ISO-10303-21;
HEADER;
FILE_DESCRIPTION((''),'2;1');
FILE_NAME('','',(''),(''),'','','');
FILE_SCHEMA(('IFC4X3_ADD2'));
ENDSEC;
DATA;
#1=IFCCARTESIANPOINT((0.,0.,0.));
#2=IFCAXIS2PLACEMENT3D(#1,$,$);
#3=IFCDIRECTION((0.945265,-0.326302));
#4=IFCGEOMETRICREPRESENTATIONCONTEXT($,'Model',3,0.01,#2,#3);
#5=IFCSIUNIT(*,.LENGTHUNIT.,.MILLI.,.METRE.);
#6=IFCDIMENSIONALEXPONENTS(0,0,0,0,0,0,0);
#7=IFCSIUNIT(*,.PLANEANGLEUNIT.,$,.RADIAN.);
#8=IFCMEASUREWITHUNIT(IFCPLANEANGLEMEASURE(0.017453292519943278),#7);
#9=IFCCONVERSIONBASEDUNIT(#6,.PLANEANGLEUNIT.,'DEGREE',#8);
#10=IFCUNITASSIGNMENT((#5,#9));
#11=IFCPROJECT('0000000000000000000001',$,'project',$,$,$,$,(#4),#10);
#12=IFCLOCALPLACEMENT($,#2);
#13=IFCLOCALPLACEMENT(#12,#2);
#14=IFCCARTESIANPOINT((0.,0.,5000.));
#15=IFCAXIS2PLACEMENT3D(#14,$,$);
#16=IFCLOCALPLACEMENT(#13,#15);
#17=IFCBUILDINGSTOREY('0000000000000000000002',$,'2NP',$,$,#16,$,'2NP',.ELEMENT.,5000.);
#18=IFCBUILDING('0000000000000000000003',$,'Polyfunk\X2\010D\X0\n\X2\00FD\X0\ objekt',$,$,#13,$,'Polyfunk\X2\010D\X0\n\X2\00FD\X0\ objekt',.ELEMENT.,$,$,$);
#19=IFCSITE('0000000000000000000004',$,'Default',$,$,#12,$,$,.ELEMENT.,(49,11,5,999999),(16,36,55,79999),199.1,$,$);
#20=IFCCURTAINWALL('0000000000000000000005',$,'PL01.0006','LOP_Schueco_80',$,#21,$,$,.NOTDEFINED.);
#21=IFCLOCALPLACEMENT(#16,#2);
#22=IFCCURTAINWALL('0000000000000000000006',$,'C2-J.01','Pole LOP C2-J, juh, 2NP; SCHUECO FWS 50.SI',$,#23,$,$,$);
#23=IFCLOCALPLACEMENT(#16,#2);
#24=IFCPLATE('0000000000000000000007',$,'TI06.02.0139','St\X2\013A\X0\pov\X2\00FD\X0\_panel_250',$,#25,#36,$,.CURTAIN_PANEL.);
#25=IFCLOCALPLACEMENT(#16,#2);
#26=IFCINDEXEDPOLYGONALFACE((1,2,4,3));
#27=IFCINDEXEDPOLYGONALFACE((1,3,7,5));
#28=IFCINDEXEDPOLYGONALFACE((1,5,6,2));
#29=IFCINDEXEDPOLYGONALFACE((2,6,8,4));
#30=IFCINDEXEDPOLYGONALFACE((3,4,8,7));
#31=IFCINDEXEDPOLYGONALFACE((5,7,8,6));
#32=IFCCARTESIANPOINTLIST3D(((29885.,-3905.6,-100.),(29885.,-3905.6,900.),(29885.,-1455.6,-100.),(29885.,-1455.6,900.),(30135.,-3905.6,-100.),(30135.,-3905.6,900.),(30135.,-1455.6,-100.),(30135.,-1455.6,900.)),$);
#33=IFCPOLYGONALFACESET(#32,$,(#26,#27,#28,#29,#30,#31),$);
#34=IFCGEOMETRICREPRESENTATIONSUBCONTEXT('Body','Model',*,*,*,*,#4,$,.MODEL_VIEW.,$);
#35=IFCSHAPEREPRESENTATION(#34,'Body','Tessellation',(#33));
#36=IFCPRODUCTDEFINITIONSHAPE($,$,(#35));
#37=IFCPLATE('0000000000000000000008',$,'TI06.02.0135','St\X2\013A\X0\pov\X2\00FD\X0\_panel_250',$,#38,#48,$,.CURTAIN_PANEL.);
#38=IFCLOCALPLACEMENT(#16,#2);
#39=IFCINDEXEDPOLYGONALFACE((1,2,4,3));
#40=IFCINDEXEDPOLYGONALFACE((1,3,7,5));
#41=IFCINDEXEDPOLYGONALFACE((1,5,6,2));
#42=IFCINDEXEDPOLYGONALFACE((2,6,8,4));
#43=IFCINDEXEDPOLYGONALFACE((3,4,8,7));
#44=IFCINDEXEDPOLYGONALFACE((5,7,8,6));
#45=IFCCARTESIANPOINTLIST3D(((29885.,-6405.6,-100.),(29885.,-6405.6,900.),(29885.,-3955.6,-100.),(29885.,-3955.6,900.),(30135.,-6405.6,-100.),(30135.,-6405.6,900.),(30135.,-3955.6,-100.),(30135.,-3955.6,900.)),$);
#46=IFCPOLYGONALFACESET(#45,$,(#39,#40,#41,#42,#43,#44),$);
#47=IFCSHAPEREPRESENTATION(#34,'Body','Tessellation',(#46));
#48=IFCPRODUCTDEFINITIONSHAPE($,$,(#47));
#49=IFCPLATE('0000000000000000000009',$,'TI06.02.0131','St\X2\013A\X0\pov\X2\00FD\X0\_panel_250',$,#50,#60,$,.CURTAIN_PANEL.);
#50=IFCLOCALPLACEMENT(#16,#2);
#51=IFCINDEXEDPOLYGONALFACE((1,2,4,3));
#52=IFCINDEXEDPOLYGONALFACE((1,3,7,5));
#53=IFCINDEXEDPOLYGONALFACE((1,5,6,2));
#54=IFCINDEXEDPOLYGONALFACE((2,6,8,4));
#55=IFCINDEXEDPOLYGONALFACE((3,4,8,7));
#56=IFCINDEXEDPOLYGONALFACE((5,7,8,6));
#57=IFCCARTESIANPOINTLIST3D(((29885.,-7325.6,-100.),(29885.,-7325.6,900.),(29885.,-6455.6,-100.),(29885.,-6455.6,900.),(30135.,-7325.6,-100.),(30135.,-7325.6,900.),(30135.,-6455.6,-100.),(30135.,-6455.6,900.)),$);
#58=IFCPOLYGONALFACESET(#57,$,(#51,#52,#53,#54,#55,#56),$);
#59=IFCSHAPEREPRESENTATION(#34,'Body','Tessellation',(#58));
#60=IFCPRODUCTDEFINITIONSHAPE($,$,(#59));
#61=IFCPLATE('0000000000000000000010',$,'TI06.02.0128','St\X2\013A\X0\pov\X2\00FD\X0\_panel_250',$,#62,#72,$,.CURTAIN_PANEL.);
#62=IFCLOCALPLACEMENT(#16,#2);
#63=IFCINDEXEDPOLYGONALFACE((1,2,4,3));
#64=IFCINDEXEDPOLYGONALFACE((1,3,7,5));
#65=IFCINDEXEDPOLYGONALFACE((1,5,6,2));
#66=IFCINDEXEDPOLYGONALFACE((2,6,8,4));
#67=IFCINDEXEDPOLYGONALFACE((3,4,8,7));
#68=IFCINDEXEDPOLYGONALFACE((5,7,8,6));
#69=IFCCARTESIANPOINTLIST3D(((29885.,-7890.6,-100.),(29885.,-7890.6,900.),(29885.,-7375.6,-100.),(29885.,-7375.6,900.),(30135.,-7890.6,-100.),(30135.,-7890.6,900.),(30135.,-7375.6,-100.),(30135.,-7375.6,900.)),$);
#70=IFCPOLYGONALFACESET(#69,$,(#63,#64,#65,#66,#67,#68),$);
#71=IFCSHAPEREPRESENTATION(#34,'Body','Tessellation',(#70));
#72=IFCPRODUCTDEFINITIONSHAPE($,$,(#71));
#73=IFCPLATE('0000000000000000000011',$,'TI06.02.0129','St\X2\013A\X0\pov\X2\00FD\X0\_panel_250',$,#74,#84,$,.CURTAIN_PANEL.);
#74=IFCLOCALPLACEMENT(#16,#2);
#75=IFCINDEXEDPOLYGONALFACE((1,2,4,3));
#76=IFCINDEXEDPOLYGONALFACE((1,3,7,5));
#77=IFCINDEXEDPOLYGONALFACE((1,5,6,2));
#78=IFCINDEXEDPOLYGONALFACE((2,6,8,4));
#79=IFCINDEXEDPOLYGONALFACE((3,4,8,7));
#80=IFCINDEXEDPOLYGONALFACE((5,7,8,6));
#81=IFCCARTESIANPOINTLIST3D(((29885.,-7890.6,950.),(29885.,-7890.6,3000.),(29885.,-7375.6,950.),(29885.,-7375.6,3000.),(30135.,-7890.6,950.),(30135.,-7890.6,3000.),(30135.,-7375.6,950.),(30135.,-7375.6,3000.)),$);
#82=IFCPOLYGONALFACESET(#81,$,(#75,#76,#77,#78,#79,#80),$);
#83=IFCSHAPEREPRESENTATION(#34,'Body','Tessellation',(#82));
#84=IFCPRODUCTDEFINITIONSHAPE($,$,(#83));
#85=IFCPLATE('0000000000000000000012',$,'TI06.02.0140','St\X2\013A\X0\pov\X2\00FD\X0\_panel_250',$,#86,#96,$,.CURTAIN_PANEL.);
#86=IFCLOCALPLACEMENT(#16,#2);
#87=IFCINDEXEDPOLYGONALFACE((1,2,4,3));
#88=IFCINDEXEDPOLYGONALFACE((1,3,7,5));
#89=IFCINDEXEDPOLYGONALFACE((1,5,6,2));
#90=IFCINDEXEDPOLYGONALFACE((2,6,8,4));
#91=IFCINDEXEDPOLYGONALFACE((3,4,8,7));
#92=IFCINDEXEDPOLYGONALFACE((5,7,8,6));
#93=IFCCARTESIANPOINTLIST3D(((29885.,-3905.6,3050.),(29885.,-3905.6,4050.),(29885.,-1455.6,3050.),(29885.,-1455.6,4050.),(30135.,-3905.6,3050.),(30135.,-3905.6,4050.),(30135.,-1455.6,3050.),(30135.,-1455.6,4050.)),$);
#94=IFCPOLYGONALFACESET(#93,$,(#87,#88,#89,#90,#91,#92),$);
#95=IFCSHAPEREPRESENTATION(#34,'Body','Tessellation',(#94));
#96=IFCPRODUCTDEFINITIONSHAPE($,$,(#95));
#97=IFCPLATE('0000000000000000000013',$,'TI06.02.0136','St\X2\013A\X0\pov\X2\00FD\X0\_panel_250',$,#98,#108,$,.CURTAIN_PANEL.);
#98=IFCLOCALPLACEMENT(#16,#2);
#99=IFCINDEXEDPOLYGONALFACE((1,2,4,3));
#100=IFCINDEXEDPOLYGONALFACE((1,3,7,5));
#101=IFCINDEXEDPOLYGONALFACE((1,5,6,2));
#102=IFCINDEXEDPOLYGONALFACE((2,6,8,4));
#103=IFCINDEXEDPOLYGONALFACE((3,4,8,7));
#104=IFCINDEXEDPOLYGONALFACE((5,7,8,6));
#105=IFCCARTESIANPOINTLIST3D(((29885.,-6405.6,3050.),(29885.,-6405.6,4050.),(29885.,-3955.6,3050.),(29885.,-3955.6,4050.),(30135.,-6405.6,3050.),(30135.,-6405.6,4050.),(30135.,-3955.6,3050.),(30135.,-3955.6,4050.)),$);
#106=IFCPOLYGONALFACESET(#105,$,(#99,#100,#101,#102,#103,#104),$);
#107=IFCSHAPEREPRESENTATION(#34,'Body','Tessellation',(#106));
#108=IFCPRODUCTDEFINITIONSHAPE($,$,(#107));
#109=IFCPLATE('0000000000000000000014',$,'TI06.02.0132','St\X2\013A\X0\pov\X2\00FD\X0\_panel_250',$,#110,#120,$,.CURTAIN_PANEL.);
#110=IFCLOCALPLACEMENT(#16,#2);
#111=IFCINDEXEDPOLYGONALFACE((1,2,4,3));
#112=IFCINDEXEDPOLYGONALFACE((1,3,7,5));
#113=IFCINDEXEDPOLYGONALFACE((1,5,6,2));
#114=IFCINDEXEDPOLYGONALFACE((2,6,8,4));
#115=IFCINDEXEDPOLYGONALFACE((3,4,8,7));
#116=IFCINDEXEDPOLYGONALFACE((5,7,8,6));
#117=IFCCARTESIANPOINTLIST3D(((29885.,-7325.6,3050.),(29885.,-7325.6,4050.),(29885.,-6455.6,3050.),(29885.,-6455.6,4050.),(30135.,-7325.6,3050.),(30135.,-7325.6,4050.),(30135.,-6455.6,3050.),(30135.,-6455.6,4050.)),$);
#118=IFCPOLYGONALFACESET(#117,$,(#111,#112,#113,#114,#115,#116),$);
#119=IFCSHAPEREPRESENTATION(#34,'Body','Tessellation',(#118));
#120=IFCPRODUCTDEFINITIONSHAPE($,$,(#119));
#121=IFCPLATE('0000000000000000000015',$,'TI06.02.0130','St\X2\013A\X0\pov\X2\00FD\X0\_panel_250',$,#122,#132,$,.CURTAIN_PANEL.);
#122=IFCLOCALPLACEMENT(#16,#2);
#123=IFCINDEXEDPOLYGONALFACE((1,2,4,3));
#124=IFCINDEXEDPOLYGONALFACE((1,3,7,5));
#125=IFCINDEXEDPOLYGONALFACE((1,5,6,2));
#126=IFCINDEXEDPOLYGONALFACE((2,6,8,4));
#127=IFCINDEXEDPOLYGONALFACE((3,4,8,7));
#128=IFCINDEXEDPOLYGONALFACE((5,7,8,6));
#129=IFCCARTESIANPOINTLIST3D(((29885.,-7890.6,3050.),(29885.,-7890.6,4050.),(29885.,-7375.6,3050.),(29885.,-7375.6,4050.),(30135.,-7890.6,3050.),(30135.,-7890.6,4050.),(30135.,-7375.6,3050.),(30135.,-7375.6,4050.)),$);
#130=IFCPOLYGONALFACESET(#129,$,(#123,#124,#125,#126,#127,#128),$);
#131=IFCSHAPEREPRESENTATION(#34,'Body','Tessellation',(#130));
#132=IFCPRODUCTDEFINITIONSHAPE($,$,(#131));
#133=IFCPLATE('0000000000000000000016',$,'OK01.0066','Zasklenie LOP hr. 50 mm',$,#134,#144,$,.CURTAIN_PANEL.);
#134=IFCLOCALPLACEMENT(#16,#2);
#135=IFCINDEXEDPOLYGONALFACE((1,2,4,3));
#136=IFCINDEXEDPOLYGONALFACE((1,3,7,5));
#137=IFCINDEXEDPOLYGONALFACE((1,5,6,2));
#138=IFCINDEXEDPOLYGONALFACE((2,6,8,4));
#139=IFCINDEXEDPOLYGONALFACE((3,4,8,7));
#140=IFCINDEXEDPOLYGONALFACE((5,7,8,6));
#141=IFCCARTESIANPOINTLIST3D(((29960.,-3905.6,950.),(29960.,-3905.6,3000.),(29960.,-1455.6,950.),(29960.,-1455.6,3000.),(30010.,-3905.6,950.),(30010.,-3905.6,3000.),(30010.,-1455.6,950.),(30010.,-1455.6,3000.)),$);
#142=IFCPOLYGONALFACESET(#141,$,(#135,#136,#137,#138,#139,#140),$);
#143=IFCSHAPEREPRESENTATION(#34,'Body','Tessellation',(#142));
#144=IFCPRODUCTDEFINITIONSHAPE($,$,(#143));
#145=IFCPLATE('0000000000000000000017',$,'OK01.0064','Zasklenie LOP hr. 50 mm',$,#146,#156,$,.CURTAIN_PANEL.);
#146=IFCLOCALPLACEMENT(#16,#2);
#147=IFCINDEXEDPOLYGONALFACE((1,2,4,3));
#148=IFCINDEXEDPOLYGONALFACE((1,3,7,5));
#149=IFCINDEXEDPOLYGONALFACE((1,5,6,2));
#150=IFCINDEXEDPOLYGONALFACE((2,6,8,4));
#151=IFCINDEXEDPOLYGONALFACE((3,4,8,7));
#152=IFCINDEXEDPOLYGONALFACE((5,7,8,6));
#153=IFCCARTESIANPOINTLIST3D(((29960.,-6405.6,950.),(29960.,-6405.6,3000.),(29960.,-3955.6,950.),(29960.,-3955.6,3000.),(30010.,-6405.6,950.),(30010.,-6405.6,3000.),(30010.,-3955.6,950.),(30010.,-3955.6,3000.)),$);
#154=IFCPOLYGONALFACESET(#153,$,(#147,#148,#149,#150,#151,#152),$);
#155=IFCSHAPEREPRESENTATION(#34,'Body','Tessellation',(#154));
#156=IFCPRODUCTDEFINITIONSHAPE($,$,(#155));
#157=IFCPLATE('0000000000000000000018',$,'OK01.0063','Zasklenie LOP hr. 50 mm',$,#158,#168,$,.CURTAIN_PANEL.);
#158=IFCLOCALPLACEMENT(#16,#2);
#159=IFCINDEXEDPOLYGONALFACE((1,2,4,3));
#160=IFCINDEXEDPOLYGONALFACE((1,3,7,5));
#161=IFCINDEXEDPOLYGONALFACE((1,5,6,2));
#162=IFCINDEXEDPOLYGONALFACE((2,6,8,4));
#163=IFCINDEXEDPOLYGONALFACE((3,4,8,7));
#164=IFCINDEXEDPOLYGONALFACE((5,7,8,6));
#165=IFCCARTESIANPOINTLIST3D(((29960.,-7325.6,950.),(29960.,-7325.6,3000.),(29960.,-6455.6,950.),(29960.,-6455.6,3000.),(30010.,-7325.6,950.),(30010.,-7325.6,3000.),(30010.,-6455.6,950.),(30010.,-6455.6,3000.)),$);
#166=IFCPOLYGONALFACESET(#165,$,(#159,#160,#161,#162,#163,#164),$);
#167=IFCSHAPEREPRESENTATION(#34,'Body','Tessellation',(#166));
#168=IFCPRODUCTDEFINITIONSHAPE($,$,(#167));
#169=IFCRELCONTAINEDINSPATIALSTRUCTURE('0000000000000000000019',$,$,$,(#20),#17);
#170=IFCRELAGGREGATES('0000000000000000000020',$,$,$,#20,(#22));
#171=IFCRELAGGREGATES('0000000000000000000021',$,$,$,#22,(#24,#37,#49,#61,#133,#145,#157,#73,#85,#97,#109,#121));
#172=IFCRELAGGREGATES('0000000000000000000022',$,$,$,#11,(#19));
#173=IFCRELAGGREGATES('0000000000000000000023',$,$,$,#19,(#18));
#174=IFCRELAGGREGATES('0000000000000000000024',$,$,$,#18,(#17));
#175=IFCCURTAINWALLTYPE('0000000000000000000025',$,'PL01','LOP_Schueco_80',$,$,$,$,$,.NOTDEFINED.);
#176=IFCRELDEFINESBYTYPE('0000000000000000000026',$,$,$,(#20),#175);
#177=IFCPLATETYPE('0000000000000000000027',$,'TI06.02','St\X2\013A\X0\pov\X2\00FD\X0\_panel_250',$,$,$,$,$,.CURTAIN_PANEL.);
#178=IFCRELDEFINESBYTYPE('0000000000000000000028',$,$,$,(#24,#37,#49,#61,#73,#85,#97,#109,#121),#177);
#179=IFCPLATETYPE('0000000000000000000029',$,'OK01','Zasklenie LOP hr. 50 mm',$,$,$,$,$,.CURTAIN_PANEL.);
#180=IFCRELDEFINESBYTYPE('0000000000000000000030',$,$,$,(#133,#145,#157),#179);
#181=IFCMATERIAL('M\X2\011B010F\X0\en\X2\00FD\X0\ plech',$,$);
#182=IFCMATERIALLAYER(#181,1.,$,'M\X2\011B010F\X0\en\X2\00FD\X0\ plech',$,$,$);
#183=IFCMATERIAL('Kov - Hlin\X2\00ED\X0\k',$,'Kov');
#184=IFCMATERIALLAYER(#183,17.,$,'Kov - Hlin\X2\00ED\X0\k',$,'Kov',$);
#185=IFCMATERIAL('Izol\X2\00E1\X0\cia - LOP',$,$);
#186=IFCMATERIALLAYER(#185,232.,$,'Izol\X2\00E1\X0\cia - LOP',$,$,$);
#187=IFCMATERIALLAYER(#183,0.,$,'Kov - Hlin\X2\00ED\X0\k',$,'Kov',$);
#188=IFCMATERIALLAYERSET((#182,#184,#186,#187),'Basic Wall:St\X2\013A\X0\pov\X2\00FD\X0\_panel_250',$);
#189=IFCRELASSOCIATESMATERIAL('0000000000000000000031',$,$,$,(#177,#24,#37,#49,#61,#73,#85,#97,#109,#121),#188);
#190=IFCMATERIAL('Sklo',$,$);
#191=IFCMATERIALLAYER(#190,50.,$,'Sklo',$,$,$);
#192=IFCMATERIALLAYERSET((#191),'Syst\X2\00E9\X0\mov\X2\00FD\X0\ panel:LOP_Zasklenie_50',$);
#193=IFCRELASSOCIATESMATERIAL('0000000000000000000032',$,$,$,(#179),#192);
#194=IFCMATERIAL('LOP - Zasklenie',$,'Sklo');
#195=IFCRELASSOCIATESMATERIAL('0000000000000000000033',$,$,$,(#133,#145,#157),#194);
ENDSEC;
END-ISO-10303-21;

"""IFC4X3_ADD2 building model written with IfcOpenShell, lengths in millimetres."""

from ifc_helpers import new_model, entity, si_unit, converted_unit, direction, frame, frame_2d, origin, origin_2d_with_axis, place, context, subcontext, project, spatial, rectangle, extrude, source, transform, mapped, material, layer, layer_set, layer_usage, type_object, type_shapes, element, aggregate, save


model = new_model("IFC4X3_ADD2")

# Units and contexts
model_context = context("Model", 3, precision=0.01, world=origin(), true_north=direction((0.945265, -0.326302)))
body_context = subcontext(model_context, "Body", "Model", "MODEL_VIEW")
ifc_project = project(units=[si_unit("LENGTHUNIT", "METRE", prefix="MILLI"), converted_unit("PLANEANGLEUNIT", "DEGREE", entity("IfcPlaneAngleMeasure", 0.017453292519943278), si_unit("PLANEANGLEUNIT", "RADIAN"), dimensions=[0, 0, 0, 0, 0, 0, 0])], contexts=[model_context])

# Site, building, storey
site_placement = place(None, origin())
site = spatial("IfcSite", under=ifc_project, at=site_placement, Name="Default", CompositionType="ELEMENT", RefLatitude=(49, 11, 5, 999999), RefLongitude=(16, 36, 55, 79999), RefElevation=199.1)
building_placement = place(site_placement, origin())
building = spatial("IfcBuilding", under=site, at=building_placement, Name="Polyfunkčný objekt", LongName="Polyfunkčný objekt", CompositionType="ELEMENT")
storey_placement = place(building_placement, frame((0.0, 0.0, 5000.0)))
storey = spatial("IfcBuildingStorey", under=building, at=storey_placement, Name="2NP", LongName="2NP", CompositionType="ELEMENT", Elevation=5000.0)

# Curtain walls
curtain_wall_type = type_object("IfcCurtainWallType", Name="PL01", Description="LOP_Schueco_80", PredefinedType="NOTDEFINED")
curtain_wall_1_placement = place(storey_placement, frame((0.0, 0.0, -5000.0)))
curtain_wall_1 = element("IfcCurtainWall", 1, at=curtain_wall_1_placement, inside=storey, type_object=curtain_wall_type, Name="PL01.0006", Description="LOP_Schueco_80", PredefinedType="NOTDEFINED")
curtain_wall_2 = element("IfcCurtainWall", 2, Name="C2-J.01", Description="Pole LOP C2-J, juh, 2NP; SCHUECO FWS 50.SI")
aggregate(curtain_wall_1, [curtain_wall_2])

# Shared definitions
ifc_material_1 = material(Name="Měďený plech")
ifc_layer_1 = layer(ifc_material_1, 1.0, Name="Měďený plech")
ifc_material_2 = material(Name="Kov - Hliník", Category="Kov")
ifc_layer_2 = layer(ifc_material_2, 17.0, Name="Kov - Hliník", Category="Kov")
ifc_material_3 = material(Name="Izolácia - LOP")
ifc_layer_3 = layer(ifc_material_3, 232.0, Name="Izolácia - LOP")
ifc_layer_4 = layer(ifc_material_2, 0.0, Name="Kov - Hliník", Category="Kov")
ifc_layer_set_1 = layer_set([ifc_layer_1, ifc_layer_2, ifc_layer_3, ifc_layer_4], Name="Basic Wall:Stĺpový_panel_250")
plate_type_1 = type_object("IfcPlateType", Name="TI06.02", Description="Stĺpový_panel_250", PredefinedType="CURTAIN_PANEL", material=ifc_layer_set_1)

# Plates
ifc_layer_usage_1 = layer_usage(ifc_layer_set_1, "AXIS2", "POSITIVE", -125.0)
plate_1_placement = place(storey_placement, frame((30010.0, -1455.6, -100.0), z_axis=(0.0, 0.0, 1.0), x_axis=(0.0, -1.0, 0.0)))
plate_1 = element("IfcPlate", 3, at=plate_1_placement, type_object=plate_type_1, material=ifc_layer_usage_1, Name="TI06.02.0139", Description="Stĺpový_panel_250", PredefinedType="CURTAIN_PANEL", context=body_context, shape_type="SweptSolid", body=[
    extrude(rectangle(XDim=250.0, YDim=2450.0, at=origin_2d_with_axis()), frame((1225.0, 0.0, 0.0), z_axis=(0.0, 0.0, 1.0), x_axis=(0.0, 1.0, 0.0)), (0.0, 0.0, 1.0), 1000.0),
])
ifc_layer_usage_2 = layer_usage(ifc_layer_set_1, "AXIS2", "POSITIVE", -125.0)
plate_2_placement = place(storey_placement, frame((30010.0, -3955.6, -100.0), z_axis=(0.0, 0.0, 1.0), x_axis=(0.0, -1.0, 0.0)))
plate_2 = element("IfcPlate", 4, at=plate_2_placement, type_object=plate_type_1, material=ifc_layer_usage_2, Name="TI06.02.0135", Description="Stĺpový_panel_250", PredefinedType="CURTAIN_PANEL", context=body_context, shape_type="SweptSolid", body=[
    extrude(rectangle(XDim=250.0, YDim=2450.0, at=frame_2d((0.0, 0.0), x_axis=(1.0, 0.0))), frame((1225.0, 0.0, 0.0), z_axis=(0.0, 0.0, 1.0), x_axis=(0.0, 1.0, 0.0)), (0.0, 0.0, 1.0), 1000.0),
])
ifc_layer_usage_3 = layer_usage(ifc_layer_set_1, "AXIS2", "POSITIVE", -125.0)
plate_3_placement = place(storey_placement, frame((30010.0, -6455.6, -100.0), z_axis=(0.0, 0.0, 1.0), x_axis=(0.0, -1.0, 0.0)))
plate_3 = element("IfcPlate", 5, at=plate_3_placement, type_object=plate_type_1, material=ifc_layer_usage_3, Name="TI06.02.0131", Description="Stĺpový_panel_250", PredefinedType="CURTAIN_PANEL", context=body_context, shape_type="SweptSolid", body=[
    extrude(rectangle(XDim=250.0, YDim=870.0, at=frame_2d((0.0, 0.0), x_axis=(1.0, 0.0))), frame((435.0, 0.0, 0.0), z_axis=(0.0, 0.0, 1.0), x_axis=(0.0, 1.0, 0.0)), (0.0, 0.0, 1.0), 1000.0),
])
ifc_layer_usage_4 = layer_usage(ifc_layer_set_1, "AXIS2", "POSITIVE", -125.0)
plate_4_placement = place(storey_placement, frame((30010.0, -7375.6, -100.0), z_axis=(0.0, 0.0, 1.0), x_axis=(0.0, -1.0, 0.0)))
plate_4 = element("IfcPlate", 6, at=plate_4_placement, type_object=plate_type_1, material=ifc_layer_usage_4, Name="TI06.02.0128", Description="Stĺpový_panel_250", PredefinedType="CURTAIN_PANEL", context=body_context, shape_type="SweptSolid", body=[
    extrude(rectangle(XDim=250.0, YDim=515.0, at=frame_2d((0.0, 0.0), x_axis=(1.0, 0.0))), frame((257.5, 0.0, 0.0), z_axis=(0.0, 0.0, 1.0), x_axis=(0.0, 1.0, 0.0)), (0.0, 0.0, 1.0), 1000.0),
])
ifc_layer_usage_5 = layer_usage(ifc_layer_set_1, "AXIS2", "POSITIVE", -125.0)
plate_5_placement = place(storey_placement, frame((30010.0, -7375.6, 950.0), z_axis=(0.0, 0.0, 1.0), x_axis=(0.0, -1.0, 0.0)))
plate_5 = element("IfcPlate", 7, at=plate_5_placement, type_object=plate_type_1, material=ifc_layer_usage_5, Name="TI06.02.0129", Description="Stĺpový_panel_250", PredefinedType="CURTAIN_PANEL", context=body_context, shape_type="SweptSolid", body=[
    extrude(rectangle(XDim=250.0, YDim=515.0, at=frame_2d((0.0, 0.0), x_axis=(1.0, 0.0))), frame((257.5, 0.0, 0.0), z_axis=(0.0, 0.0, 1.0), x_axis=(0.0, 1.0, 0.0)), (0.0, 0.0, 1.0), 2050.0),
])
ifc_layer_usage_6 = layer_usage(ifc_layer_set_1, "AXIS2", "POSITIVE", -125.0)
plate_6_placement = place(storey_placement, frame((30010.0, -1455.6, 3050.0), z_axis=(0.0, 0.0, 1.0), x_axis=(0.0, -1.0, 0.0)))
plate_6 = element("IfcPlate", 8, at=plate_6_placement, type_object=plate_type_1, material=ifc_layer_usage_6, Name="TI06.02.0140", Description="Stĺpový_panel_250", PredefinedType="CURTAIN_PANEL", context=body_context, shape_type="SweptSolid", body=[
    extrude(rectangle(XDim=250.0, YDim=2450.0, at=origin_2d_with_axis()), frame((1225.0, 0.0, 0.0), z_axis=(0.0, 0.0, 1.0), x_axis=(0.0, 1.0, 0.0)), (0.0, 0.0, 1.0), 1000.0),
])
ifc_layer_usage_7 = layer_usage(ifc_layer_set_1, "AXIS2", "POSITIVE", -125.0)
plate_7_placement = place(storey_placement, frame((30010.0, -3955.6, 3050.0), z_axis=(0.0, 0.0, 1.0), x_axis=(0.0, -1.0, 0.0)))
plate_7 = element("IfcPlate", 9, at=plate_7_placement, type_object=plate_type_1, material=ifc_layer_usage_7, Name="TI06.02.0136", Description="Stĺpový_panel_250", PredefinedType="CURTAIN_PANEL", context=body_context, shape_type="SweptSolid", body=[
    extrude(rectangle(XDim=250.0, YDim=2450.0, at=frame_2d((0.0, 0.0), x_axis=(1.0, 0.0))), frame((1225.0, 0.0, 0.0), z_axis=(0.0, 0.0, 1.0), x_axis=(0.0, 1.0, 0.0)), (0.0, 0.0, 1.0), 1000.0),
])
ifc_layer_usage_8 = layer_usage(ifc_layer_set_1, "AXIS2", "POSITIVE", -125.0)
plate_8_placement = place(storey_placement, frame((30010.0, -6455.6, 3050.0), z_axis=(0.0, 0.0, 1.0), x_axis=(0.0, -1.0, 0.0)))
plate_8 = element("IfcPlate", 10, at=plate_8_placement, type_object=plate_type_1, material=ifc_layer_usage_8, Name="TI06.02.0132", Description="Stĺpový_panel_250", PredefinedType="CURTAIN_PANEL", context=body_context, shape_type="SweptSolid", body=[
    extrude(rectangle(XDim=250.0, YDim=870.0, at=frame_2d((0.0, 0.0), x_axis=(1.0, 0.0))), frame((435.0, 0.0, 0.0), z_axis=(0.0, 0.0, 1.0), x_axis=(0.0, 1.0, 0.0)), (0.0, 0.0, 1.0), 1000.0),
])
ifc_layer_usage_9 = layer_usage(ifc_layer_set_1, "AXIS2", "POSITIVE", -125.0)
plate_9_placement = place(storey_placement, frame((30010.0, -7375.6, 3050.0), z_axis=(0.0, 0.0, 1.0), x_axis=(0.0, -1.0, 0.0)))
plate_9 = element("IfcPlate", 11, at=plate_9_placement, type_object=plate_type_1, material=ifc_layer_usage_9, Name="TI06.02.0130", Description="Stĺpový_panel_250", PredefinedType="CURTAIN_PANEL", context=body_context, shape_type="SweptSolid", body=[
    extrude(rectangle(XDim=250.0, YDim=515.0, at=frame_2d((0.0, 0.0), x_axis=(1.0, 0.0))), frame((257.5, 0.0, 0.0), z_axis=(0.0, 0.0, 1.0), x_axis=(0.0, 1.0, 0.0)), (0.0, 0.0, 1.0), 1000.0),
])
ifc_material_4 = material(Name="LOP - Zasklenie", Category="Sklo")
ifc_material_5 = material(Name="Sklo")
ifc_layer_5 = layer(ifc_material_5, 50.0, Name="Sklo")
ifc_layer_set_2 = layer_set([ifc_layer_5], Name="Systémový panel:LOP_Zasklenie_50")
plate_type_2 = type_object("IfcPlateType", Name="OK01", Description="Zasklenie LOP hr. 50 mm", PredefinedType="CURTAIN_PANEL", material=ifc_layer_set_2)
shared_shape_1 = source(origin(), body_context, "Body", "SweptSolid", [
    extrude(rectangle(XDim=50.0, YDim=2450.0, at=origin_2d_with_axis()), frame((0.0, -25.0, 0.0), z_axis=(0.0, 0.0, 1.0), x_axis=(0.0, 1.0, 0.0)), (0.0, 0.0, 1.0), 2050.0),
])
plate_10_placement = place(curtain_wall_1_placement, frame((30010.0, -2680.6, 5950.0), z_axis=(0.0, 0.0, 1.0), x_axis=(0.0, -1.0, 0.0)))
plate_10 = element("IfcPlate", 12, at=plate_10_placement, type_object=plate_type_2, material=ifc_material_4, Name="OK01.0066", Description="Zasklenie LOP hr. 50 mm", PredefinedType="CURTAIN_PANEL", context=body_context, shape_type="MappedRepresentation", body=[
    mapped(shared_shape_1, transform((0.0, 0.0, 0.0), scale=1.0)),
])
plate_11_placement = place(curtain_wall_1_placement, frame((30010.0, -5180.6, 5950.0), z_axis=(0.0, 0.0, 1.0), x_axis=(0.0, -1.0, 0.0)))
plate_11 = element("IfcPlate", 13, at=plate_11_placement, type_object=plate_type_2, material=ifc_material_4, Name="OK01.0064", Description="Zasklenie LOP hr. 50 mm", PredefinedType="CURTAIN_PANEL", context=body_context, shape_type="MappedRepresentation", body=[
    mapped(shared_shape_1, transform((0.0, 0.0, 0.0), scale=1.0)),
])
shared_shape_2 = source(origin(), body_context, "Body", "SweptSolid", [
    extrude(rectangle(XDim=50.0, YDim=870.0, at=origin_2d_with_axis()), frame((0.0, -25.0, 0.0), z_axis=(0.0, 0.0, 1.0), x_axis=(0.0, 1.0, 0.0)), (0.0, 0.0, 1.0), 2050.0),
])
type_shapes(plate_type_2, [shared_shape_1, shared_shape_2])
plate_12_placement = place(curtain_wall_1_placement, frame((30010.0, -6890.6, 5950.0), z_axis=(0.0, 0.0, 1.0), x_axis=(0.0, -1.0, 0.0)))
plate_12 = element("IfcPlate", 14, at=plate_12_placement, type_object=plate_type_2, material=ifc_material_4, Name="OK01.0063", Description="Zasklenie LOP hr. 50 mm", PredefinedType="CURTAIN_PANEL", context=body_context, shape_type="MappedRepresentation", body=[
    mapped(shared_shape_2, transform((0.0, 0.0, 0.0), scale=1.0)),
])
aggregate(curtain_wall_2, [plate_1, plate_2, plate_3, plate_4, plate_10, plate_11, plate_12, plate_5, plate_6, plate_7, plate_8, plate_9])

save(model, "model.ifc")
